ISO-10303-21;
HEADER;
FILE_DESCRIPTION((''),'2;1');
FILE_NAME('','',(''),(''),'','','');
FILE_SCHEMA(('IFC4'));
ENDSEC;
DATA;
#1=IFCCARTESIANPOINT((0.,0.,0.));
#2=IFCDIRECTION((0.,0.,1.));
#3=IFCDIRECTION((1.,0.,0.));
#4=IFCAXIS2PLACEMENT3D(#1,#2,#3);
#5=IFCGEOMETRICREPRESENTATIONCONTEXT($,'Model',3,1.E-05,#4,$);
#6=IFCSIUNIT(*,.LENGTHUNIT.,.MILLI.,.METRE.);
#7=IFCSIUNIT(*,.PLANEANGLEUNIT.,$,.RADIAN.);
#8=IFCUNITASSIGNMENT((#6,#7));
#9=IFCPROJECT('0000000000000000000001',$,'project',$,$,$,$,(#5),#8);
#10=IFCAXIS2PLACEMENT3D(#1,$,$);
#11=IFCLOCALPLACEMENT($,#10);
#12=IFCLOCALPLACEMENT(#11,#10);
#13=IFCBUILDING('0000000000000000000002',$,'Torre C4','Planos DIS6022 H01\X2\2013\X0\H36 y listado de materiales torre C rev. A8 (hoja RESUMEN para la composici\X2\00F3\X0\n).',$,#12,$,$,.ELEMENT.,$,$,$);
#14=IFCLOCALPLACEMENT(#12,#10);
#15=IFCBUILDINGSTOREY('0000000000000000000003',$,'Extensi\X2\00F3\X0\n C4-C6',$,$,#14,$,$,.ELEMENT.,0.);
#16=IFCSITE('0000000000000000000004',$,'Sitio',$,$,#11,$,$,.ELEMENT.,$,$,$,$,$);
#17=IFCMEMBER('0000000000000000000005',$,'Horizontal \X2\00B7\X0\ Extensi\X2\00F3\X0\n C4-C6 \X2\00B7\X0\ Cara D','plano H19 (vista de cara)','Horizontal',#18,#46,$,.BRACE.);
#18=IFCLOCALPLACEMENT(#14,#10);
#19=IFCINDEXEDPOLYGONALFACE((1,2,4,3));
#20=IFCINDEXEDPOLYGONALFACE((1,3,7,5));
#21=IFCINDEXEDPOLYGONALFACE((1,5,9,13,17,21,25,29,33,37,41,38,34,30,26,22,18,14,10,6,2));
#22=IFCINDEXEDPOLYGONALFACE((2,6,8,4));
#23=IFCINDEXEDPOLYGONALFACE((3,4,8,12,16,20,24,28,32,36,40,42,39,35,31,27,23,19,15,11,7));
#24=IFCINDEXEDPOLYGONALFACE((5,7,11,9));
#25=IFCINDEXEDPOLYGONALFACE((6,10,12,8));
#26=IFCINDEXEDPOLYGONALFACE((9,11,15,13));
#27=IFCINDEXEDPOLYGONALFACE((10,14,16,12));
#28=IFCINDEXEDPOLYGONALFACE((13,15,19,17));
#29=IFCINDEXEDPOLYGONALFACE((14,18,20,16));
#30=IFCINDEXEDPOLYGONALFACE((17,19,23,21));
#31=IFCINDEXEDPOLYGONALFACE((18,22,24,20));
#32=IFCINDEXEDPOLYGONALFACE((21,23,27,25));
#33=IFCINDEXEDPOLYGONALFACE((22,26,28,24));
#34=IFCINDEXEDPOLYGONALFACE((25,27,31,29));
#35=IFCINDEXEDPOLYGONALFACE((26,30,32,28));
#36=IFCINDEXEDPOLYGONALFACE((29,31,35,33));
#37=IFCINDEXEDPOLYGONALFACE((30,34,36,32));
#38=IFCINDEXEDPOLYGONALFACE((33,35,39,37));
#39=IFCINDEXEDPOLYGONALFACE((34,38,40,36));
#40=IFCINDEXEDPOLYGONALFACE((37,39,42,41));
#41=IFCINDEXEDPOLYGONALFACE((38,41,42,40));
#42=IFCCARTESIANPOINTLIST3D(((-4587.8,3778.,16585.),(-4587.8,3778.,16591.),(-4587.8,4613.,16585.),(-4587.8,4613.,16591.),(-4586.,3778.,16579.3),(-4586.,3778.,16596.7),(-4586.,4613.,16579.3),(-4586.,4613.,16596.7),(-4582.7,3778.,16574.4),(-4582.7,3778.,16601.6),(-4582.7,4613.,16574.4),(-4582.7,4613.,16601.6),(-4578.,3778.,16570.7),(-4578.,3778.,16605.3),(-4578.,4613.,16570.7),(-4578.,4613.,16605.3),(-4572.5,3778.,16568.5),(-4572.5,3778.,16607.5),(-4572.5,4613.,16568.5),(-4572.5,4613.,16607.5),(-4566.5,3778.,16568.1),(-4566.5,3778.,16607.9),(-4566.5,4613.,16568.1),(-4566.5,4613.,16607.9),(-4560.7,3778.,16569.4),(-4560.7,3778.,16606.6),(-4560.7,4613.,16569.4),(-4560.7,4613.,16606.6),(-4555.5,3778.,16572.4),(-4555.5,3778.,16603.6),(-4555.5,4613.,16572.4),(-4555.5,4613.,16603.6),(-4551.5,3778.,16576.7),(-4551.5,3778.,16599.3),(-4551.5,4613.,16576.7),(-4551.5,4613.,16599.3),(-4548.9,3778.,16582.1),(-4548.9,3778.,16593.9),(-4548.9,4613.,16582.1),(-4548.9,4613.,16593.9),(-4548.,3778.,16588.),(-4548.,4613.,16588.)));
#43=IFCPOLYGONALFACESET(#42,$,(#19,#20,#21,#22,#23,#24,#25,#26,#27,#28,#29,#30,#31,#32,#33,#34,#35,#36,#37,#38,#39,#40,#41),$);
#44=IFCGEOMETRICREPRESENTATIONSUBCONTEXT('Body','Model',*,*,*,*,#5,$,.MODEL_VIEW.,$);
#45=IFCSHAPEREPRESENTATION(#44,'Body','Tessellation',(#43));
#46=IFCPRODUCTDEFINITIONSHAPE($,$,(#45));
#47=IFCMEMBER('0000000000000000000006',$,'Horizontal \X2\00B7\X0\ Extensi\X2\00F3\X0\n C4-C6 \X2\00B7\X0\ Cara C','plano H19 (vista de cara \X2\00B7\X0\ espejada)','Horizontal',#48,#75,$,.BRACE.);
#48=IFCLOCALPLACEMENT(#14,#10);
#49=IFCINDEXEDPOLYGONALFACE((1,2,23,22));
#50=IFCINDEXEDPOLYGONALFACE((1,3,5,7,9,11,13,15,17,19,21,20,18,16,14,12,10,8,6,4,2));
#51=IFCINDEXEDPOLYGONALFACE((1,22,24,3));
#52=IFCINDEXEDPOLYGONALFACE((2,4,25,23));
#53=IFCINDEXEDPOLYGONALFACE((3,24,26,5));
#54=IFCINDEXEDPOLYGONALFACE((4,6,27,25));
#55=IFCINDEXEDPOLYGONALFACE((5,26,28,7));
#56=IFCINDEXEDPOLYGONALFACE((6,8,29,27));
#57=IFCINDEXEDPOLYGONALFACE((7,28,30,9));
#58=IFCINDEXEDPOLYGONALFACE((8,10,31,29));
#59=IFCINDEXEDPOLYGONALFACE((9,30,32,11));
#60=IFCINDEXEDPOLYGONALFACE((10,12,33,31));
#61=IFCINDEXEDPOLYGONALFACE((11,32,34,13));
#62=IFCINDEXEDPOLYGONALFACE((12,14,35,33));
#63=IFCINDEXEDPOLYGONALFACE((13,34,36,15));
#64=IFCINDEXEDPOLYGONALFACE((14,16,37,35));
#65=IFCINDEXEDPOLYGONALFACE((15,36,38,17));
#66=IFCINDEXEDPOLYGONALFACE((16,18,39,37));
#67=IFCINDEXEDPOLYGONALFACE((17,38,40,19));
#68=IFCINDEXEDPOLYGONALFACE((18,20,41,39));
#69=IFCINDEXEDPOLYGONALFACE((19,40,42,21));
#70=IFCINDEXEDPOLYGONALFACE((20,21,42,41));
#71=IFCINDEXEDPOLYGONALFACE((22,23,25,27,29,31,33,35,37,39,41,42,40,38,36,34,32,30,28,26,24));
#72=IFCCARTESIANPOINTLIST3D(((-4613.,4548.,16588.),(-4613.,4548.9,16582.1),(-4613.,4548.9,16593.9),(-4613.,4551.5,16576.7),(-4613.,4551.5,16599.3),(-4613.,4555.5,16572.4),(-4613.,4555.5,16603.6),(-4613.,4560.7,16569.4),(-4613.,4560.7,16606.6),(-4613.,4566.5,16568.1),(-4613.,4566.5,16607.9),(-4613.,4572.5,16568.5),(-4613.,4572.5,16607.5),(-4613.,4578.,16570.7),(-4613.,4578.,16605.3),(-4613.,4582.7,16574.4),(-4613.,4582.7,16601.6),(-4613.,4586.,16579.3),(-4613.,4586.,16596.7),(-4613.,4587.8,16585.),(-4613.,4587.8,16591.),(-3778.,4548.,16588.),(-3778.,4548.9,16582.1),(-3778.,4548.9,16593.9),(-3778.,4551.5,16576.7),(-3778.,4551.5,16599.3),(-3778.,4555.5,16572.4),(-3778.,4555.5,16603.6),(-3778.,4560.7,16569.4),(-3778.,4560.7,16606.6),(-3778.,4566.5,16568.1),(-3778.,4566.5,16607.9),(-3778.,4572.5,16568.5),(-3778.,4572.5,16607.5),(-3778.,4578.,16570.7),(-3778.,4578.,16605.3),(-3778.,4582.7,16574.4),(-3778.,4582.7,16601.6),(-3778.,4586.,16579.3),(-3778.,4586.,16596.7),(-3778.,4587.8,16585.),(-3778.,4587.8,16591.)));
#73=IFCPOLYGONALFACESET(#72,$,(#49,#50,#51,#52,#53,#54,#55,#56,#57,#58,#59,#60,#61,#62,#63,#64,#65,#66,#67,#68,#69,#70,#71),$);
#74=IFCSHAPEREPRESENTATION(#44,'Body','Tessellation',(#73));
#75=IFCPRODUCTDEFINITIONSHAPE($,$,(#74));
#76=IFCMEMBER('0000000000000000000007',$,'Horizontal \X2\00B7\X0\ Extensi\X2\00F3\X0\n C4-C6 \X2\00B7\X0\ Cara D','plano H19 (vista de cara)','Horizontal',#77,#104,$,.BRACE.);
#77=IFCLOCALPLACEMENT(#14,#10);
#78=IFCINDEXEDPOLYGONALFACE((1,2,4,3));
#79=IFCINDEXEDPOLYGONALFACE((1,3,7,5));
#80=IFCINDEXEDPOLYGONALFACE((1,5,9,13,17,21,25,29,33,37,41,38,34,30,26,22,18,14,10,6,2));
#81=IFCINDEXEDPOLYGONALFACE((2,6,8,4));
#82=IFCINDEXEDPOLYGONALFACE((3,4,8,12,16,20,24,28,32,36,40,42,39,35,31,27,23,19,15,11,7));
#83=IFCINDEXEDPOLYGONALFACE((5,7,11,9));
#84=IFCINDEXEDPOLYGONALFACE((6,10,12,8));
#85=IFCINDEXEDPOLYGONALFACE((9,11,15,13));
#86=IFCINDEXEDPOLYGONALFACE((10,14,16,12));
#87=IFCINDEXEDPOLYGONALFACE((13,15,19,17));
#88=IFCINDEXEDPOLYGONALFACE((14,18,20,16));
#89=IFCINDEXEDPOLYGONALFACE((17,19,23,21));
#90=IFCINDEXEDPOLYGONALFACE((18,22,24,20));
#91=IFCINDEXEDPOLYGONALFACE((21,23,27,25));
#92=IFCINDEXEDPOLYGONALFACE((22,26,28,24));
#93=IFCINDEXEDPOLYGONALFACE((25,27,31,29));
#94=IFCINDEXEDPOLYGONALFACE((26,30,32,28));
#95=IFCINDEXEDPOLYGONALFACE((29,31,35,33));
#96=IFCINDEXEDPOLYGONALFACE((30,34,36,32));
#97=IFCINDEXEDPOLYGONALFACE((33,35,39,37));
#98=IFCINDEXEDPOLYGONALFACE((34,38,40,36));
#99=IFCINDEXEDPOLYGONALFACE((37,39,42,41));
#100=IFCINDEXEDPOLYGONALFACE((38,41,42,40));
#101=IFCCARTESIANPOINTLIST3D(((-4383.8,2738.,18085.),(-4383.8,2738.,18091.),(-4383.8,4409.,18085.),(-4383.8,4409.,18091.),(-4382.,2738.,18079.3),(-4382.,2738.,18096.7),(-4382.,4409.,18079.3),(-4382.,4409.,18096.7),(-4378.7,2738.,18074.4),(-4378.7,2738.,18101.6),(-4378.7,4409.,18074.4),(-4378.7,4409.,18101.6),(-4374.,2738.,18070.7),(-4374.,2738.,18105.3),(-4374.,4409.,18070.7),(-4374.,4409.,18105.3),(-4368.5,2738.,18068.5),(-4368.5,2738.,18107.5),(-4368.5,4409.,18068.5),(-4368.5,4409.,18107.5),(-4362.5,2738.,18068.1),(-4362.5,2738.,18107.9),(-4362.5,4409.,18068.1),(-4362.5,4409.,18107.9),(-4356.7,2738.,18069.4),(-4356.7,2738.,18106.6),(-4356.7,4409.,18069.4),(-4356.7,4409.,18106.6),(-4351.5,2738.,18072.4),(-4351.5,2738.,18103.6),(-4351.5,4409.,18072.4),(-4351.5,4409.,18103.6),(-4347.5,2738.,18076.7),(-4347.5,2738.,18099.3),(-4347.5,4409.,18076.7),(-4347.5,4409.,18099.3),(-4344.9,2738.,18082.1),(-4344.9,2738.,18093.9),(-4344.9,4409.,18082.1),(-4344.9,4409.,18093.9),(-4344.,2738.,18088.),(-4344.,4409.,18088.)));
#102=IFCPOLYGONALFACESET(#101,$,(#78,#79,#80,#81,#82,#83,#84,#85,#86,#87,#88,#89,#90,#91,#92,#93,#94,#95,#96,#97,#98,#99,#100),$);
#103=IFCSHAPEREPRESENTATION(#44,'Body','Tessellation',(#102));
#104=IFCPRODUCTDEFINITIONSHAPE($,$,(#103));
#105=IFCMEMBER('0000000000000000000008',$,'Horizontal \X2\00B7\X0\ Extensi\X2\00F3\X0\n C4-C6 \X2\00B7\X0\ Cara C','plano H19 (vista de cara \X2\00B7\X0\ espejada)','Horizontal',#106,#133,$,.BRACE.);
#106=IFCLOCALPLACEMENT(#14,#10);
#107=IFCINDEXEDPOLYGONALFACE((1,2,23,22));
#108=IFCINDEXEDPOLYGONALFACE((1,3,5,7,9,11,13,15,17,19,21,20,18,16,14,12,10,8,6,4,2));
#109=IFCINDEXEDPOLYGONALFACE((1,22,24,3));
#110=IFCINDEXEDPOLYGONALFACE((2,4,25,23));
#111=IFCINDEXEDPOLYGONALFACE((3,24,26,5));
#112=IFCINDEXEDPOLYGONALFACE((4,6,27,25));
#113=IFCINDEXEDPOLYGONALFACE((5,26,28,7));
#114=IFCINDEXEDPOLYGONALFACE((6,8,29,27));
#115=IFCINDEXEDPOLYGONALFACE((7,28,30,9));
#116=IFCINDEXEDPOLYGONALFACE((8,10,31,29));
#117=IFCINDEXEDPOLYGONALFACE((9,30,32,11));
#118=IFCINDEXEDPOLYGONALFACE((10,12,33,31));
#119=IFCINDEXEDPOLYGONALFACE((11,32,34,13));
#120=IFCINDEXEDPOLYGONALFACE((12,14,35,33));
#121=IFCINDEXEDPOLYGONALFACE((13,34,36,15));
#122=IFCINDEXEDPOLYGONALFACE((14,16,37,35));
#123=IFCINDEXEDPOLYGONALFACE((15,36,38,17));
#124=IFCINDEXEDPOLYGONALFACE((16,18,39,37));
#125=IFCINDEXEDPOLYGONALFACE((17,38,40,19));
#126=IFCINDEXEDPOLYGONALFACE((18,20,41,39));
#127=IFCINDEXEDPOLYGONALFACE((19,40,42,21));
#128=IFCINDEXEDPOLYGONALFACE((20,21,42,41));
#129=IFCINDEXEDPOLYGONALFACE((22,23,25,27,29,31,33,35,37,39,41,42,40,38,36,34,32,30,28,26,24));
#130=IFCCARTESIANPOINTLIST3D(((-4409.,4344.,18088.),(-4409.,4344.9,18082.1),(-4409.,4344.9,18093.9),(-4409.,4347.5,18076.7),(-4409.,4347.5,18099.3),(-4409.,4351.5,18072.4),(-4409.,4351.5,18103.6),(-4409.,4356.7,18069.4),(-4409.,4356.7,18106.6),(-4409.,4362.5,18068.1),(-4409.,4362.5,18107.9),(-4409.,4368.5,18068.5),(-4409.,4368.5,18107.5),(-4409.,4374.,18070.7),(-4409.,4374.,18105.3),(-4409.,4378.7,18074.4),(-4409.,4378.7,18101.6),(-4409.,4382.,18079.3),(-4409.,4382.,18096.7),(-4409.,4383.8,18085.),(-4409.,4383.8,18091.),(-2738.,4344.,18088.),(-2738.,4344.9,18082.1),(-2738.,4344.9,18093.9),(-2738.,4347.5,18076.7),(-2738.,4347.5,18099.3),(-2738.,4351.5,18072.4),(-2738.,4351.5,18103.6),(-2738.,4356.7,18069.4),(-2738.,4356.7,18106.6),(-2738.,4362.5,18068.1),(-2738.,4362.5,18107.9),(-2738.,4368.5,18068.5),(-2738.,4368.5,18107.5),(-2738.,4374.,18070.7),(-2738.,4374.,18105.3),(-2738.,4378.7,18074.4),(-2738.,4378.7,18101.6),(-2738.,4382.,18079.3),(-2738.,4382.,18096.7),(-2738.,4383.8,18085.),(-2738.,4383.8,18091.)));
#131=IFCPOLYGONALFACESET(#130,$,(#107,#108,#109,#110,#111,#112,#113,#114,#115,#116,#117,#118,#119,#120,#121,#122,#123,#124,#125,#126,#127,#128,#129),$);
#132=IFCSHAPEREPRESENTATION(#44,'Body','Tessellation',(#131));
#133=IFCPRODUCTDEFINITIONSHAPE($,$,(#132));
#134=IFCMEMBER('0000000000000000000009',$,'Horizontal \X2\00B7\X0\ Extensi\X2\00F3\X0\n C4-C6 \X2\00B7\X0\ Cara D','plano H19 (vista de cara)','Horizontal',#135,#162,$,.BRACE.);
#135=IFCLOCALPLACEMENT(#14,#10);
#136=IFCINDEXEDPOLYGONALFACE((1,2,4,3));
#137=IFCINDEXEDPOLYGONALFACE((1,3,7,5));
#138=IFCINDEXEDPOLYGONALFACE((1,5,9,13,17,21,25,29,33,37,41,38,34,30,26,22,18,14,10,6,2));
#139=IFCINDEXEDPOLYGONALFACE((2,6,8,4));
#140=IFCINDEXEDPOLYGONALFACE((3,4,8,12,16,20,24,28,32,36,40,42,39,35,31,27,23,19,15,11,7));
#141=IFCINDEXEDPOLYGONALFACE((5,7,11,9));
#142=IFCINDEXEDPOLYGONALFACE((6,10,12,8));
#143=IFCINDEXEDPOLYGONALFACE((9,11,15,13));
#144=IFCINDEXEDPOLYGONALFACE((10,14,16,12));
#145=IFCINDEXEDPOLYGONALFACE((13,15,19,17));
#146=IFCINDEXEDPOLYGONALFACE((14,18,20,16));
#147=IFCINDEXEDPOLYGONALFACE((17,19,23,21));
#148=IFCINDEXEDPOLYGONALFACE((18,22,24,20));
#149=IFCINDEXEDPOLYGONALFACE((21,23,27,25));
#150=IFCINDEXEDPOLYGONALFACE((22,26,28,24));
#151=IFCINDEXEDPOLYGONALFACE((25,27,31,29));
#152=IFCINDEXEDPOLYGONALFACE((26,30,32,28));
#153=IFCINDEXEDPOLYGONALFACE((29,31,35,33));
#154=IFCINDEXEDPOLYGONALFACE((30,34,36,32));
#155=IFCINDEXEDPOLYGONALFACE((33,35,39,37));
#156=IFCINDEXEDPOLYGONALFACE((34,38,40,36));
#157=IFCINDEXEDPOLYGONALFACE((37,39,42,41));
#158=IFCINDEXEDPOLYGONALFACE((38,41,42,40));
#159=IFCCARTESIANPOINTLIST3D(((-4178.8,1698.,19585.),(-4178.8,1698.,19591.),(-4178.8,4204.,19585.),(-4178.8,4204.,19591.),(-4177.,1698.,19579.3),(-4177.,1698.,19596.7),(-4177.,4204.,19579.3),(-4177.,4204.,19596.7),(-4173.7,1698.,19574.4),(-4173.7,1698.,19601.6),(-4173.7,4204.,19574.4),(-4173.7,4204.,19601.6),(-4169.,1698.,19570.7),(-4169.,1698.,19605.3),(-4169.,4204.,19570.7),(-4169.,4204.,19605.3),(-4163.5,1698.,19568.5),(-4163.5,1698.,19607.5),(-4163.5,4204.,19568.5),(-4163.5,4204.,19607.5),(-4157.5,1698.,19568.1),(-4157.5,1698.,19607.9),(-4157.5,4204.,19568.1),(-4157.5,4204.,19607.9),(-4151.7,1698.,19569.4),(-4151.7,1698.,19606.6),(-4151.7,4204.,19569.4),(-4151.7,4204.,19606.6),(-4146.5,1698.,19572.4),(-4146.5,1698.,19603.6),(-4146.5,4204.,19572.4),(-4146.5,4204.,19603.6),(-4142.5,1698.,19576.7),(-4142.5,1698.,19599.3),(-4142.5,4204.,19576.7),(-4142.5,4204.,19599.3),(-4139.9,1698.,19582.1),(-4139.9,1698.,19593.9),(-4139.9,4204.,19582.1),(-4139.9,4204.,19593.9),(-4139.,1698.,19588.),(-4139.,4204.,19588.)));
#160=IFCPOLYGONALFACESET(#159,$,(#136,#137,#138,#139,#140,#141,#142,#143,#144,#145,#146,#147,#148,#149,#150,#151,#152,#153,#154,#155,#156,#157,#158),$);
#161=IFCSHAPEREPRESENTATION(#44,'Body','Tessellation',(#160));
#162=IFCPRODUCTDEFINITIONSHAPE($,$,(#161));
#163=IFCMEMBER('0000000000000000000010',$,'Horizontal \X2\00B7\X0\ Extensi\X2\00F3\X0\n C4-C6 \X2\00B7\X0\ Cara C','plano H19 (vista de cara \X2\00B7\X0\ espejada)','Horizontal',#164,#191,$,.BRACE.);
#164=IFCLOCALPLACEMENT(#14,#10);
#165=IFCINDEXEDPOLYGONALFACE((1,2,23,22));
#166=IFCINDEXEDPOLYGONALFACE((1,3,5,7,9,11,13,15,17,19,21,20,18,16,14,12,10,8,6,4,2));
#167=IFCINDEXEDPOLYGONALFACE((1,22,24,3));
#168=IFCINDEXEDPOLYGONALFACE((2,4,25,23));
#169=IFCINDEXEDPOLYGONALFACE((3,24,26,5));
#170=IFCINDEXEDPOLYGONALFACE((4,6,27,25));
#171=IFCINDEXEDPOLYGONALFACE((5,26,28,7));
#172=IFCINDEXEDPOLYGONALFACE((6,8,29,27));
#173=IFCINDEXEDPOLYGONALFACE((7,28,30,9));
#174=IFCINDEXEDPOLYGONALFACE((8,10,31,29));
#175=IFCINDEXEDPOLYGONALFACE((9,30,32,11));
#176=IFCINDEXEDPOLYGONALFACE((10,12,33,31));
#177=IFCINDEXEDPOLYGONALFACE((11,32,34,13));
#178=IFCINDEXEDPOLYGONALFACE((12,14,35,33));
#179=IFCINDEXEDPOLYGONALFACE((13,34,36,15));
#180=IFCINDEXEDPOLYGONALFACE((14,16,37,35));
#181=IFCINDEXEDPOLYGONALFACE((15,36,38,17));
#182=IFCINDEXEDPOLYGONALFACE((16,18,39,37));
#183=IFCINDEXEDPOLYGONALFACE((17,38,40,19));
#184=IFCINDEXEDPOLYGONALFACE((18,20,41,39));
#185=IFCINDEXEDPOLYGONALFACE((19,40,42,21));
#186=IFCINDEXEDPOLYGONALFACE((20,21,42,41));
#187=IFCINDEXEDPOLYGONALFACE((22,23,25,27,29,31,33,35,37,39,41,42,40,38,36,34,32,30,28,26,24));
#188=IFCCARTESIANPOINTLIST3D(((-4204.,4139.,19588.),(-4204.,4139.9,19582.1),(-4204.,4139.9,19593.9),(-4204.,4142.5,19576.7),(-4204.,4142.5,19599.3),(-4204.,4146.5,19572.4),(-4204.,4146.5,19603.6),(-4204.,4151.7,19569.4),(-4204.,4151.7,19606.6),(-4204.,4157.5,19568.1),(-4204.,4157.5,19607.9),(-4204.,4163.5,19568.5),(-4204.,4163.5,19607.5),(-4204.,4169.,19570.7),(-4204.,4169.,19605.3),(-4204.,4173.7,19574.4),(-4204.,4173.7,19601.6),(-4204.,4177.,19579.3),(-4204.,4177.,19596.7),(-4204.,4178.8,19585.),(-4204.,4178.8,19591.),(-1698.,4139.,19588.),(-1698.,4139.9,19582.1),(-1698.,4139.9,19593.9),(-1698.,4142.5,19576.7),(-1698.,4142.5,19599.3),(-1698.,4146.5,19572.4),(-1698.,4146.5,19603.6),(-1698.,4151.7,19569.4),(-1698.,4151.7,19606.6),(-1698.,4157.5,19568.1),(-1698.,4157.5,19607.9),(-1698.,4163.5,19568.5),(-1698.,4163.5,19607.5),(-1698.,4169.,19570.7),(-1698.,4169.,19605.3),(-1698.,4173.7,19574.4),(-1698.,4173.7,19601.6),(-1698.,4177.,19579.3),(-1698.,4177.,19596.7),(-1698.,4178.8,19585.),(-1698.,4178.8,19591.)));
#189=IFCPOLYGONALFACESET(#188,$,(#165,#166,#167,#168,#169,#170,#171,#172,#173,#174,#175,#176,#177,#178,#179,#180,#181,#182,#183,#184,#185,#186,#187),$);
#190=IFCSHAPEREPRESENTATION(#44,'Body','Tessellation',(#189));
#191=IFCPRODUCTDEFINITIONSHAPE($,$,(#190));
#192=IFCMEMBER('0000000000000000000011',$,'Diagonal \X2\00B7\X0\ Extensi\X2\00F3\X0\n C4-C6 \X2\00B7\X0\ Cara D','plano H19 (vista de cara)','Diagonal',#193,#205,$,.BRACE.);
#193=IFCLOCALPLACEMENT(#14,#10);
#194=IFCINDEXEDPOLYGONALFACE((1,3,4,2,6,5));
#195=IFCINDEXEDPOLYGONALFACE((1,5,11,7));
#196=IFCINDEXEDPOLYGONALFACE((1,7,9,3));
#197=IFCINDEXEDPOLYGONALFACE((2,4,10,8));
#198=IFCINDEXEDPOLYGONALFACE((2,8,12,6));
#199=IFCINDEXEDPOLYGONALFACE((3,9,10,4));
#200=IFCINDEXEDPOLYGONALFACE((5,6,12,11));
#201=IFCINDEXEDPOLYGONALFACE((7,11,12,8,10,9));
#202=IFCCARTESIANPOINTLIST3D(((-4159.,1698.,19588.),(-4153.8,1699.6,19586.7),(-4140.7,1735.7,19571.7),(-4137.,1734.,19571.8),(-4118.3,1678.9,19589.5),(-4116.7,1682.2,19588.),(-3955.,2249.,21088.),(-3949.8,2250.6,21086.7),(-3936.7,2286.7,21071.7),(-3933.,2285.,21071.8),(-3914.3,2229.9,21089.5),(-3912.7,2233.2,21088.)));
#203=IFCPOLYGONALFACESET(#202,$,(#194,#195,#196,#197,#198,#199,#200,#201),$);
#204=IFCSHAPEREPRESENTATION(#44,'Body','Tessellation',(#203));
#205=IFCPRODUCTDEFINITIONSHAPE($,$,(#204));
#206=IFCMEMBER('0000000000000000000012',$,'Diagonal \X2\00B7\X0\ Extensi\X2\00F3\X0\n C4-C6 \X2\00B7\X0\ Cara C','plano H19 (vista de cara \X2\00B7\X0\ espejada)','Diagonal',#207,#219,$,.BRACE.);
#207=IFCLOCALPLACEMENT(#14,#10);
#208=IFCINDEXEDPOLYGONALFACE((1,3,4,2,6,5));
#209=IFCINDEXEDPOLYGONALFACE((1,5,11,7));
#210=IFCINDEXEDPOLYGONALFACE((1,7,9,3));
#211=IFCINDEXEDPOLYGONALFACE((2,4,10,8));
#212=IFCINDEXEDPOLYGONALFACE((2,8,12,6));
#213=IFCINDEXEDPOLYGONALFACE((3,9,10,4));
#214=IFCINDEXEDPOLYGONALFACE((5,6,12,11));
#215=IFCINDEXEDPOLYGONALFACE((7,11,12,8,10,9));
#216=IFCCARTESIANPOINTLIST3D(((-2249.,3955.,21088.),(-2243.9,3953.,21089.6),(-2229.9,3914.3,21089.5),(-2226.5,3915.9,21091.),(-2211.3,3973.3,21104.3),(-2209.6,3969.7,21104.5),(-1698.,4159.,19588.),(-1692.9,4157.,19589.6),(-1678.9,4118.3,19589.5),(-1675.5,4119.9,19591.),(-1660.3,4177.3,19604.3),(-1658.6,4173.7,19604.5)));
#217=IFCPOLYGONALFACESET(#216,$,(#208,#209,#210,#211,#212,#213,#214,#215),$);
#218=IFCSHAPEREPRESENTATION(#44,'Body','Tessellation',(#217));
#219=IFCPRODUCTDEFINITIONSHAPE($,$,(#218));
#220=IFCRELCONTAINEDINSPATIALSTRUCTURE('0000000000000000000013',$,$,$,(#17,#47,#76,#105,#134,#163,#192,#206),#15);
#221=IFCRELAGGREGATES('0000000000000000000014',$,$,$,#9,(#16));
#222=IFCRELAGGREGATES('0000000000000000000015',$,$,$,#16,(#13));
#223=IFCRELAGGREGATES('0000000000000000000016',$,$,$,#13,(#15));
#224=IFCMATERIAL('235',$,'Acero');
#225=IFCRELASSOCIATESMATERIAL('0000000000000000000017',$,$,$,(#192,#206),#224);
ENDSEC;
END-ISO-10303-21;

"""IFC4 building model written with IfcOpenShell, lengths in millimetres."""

from ifc_helpers import new_model, si_unit, frame, frame_2d, origin, origin_with_axes, place, context, subcontext, project, spatial, circle, l_section, extrude, material, element, save


model = new_model("IFC4")

# Units and contexts
model_context = context("Model", 3, precision=1e-05, world=origin_with_axes())
body_context = subcontext(model_context, "Body", "Model", "MODEL_VIEW")
ifc_project = project(units=[si_unit("LENGTHUNIT", "METRE", prefix="MILLI"), si_unit("PLANEANGLEUNIT", "RADIAN")], contexts=[model_context])

# Site, building, storey
site_placement = place(None, origin())
site = spatial("IfcSite", under=ifc_project, at=site_placement, Name="Sitio", CompositionType="ELEMENT")
building_placement = place(site_placement, origin())
building = spatial("IfcBuilding", under=site, at=building_placement, Name="Torre C4", Description="Planos DIS6022 H01–H36 y listado de materiales torre C rev. A8 (hoja RESUMEN para la composición).", CompositionType="ELEMENT")
storey_placement = place(building_placement, origin())
storey = spatial("IfcBuildingStorey", under=building, at=storey_placement, Name="Extensión C4-C6", CompositionType="ELEMENT", Elevation=0.0)

# Members
ifc_material = material(Name="235", Category="Acero")
for number, where, z_axis, x_axis, name, description in (
    (1, (-4568.0, 3778.0, 16588.0), (0.0, 1.0, 0.0), (1.0, 0.0, 0.0), "Horizontal · Extensión C4-C6 · Cara D", "plano H19 (vista de cara)"),
    (2, (-3778.0, 4568.0, 16588.0), (-1.0, 0.0, 0.0), (0.0, -1.0, 0.0), "Horizontal · Extensión C4-C6 · Cara C", "plano H19 (vista de cara · espejada)"),
):
    element("IfcMember", number, at=place(storey_placement, frame(where, z_axis=z_axis, x_axis=x_axis)), inside=storey, Name=name, Description=description, ObjectType="Horizontal", PredefinedType="BRACE", context=body_context, shape_type="SweptSolid", body=[
        extrude(circle(Radius=20.0), None, (0.0, 0.0, 1.0), 835.0),
    ])
for number, where, z_axis, x_axis, name, description in (
    (3, (-4364.0, 2738.0, 18088.0), (0.0, 1.0, 0.0), (1.0, 0.0, 0.0), "Horizontal · Extensión C4-C6 · Cara D", "plano H19 (vista de cara)"),
    (4, (-2738.0, 4364.0, 18088.0), (-1.0, 0.0, 0.0), (0.0, -1.0, 0.0), "Horizontal · Extensión C4-C6 · Cara C", "plano H19 (vista de cara · espejada)"),
):
    element("IfcMember", number, at=place(storey_placement, frame(where, z_axis=z_axis, x_axis=x_axis)), inside=storey, Name=name, Description=description, ObjectType="Horizontal", PredefinedType="BRACE", context=body_context, shape_type="SweptSolid", body=[
        extrude(circle(Radius=20.0), None, (0.0, 0.0, 1.0), 1671.0),
    ])
for number, where, z_axis, x_axis, name, description in (
    (5, (-4159.0, 1698.0, 19588.0), (0.0, 1.0, 0.0), (1.0, 0.0, 0.0), "Horizontal · Extensión C4-C6 · Cara D", "plano H19 (vista de cara)"),
    (6, (-1698.0, 4159.0, 19588.0), (-1.0, 0.0, 0.0), (0.0, -1.0, 0.0), "Horizontal · Extensión C4-C6 · Cara C", "plano H19 (vista de cara · espejada)"),
):
    element("IfcMember", number, at=place(storey_placement, frame(where, z_axis=z_axis, x_axis=x_axis)), inside=storey, Name=name, Description=description, ObjectType="Horizontal", PredefinedType="BRACE", context=body_context, shape_type="SweptSolid", body=[
        extrude(circle(Radius=20.0), None, (0.0, 0.0, 1.0), 2506.0),
    ])
for number, where, z_axis, x_axis, name, description in (
    (7, (-4159.0, 1698.0, 19588.0), (0.126632, 0.34203, 0.931117), (0.904354, -0.425481, 0.033301), "Diagonal · Extensión C4-C6 · Cara D", "plano H19 (vista de cara)"),
    (8, (-1698.0, 4159.0, 19588.0), (-0.34203, -0.126632, 0.931117), (0.425481, -0.904354, 0.033301), "Diagonal · Extensión C4-C6 · Cara C", "plano H19 (vista de cara · espejada)"),
):
    element("IfcMember", number, at=place(storey_placement, frame(where, z_axis=z_axis, x_axis=x_axis)), inside=storey, material=ifc_material, Name=name, Description=description, ObjectType="Diagonal", PredefinedType="BRACE", context=body_context, shape_type="SweptSolid", body=[
        extrude(l_section(Depth=45.0, Width=45.0, Thickness=4.0, at=frame_2d((22.5, 22.5))), None, (0.0, 0.0, 1.0), 1611.0),
    ])

save(model, "model.ifc")
